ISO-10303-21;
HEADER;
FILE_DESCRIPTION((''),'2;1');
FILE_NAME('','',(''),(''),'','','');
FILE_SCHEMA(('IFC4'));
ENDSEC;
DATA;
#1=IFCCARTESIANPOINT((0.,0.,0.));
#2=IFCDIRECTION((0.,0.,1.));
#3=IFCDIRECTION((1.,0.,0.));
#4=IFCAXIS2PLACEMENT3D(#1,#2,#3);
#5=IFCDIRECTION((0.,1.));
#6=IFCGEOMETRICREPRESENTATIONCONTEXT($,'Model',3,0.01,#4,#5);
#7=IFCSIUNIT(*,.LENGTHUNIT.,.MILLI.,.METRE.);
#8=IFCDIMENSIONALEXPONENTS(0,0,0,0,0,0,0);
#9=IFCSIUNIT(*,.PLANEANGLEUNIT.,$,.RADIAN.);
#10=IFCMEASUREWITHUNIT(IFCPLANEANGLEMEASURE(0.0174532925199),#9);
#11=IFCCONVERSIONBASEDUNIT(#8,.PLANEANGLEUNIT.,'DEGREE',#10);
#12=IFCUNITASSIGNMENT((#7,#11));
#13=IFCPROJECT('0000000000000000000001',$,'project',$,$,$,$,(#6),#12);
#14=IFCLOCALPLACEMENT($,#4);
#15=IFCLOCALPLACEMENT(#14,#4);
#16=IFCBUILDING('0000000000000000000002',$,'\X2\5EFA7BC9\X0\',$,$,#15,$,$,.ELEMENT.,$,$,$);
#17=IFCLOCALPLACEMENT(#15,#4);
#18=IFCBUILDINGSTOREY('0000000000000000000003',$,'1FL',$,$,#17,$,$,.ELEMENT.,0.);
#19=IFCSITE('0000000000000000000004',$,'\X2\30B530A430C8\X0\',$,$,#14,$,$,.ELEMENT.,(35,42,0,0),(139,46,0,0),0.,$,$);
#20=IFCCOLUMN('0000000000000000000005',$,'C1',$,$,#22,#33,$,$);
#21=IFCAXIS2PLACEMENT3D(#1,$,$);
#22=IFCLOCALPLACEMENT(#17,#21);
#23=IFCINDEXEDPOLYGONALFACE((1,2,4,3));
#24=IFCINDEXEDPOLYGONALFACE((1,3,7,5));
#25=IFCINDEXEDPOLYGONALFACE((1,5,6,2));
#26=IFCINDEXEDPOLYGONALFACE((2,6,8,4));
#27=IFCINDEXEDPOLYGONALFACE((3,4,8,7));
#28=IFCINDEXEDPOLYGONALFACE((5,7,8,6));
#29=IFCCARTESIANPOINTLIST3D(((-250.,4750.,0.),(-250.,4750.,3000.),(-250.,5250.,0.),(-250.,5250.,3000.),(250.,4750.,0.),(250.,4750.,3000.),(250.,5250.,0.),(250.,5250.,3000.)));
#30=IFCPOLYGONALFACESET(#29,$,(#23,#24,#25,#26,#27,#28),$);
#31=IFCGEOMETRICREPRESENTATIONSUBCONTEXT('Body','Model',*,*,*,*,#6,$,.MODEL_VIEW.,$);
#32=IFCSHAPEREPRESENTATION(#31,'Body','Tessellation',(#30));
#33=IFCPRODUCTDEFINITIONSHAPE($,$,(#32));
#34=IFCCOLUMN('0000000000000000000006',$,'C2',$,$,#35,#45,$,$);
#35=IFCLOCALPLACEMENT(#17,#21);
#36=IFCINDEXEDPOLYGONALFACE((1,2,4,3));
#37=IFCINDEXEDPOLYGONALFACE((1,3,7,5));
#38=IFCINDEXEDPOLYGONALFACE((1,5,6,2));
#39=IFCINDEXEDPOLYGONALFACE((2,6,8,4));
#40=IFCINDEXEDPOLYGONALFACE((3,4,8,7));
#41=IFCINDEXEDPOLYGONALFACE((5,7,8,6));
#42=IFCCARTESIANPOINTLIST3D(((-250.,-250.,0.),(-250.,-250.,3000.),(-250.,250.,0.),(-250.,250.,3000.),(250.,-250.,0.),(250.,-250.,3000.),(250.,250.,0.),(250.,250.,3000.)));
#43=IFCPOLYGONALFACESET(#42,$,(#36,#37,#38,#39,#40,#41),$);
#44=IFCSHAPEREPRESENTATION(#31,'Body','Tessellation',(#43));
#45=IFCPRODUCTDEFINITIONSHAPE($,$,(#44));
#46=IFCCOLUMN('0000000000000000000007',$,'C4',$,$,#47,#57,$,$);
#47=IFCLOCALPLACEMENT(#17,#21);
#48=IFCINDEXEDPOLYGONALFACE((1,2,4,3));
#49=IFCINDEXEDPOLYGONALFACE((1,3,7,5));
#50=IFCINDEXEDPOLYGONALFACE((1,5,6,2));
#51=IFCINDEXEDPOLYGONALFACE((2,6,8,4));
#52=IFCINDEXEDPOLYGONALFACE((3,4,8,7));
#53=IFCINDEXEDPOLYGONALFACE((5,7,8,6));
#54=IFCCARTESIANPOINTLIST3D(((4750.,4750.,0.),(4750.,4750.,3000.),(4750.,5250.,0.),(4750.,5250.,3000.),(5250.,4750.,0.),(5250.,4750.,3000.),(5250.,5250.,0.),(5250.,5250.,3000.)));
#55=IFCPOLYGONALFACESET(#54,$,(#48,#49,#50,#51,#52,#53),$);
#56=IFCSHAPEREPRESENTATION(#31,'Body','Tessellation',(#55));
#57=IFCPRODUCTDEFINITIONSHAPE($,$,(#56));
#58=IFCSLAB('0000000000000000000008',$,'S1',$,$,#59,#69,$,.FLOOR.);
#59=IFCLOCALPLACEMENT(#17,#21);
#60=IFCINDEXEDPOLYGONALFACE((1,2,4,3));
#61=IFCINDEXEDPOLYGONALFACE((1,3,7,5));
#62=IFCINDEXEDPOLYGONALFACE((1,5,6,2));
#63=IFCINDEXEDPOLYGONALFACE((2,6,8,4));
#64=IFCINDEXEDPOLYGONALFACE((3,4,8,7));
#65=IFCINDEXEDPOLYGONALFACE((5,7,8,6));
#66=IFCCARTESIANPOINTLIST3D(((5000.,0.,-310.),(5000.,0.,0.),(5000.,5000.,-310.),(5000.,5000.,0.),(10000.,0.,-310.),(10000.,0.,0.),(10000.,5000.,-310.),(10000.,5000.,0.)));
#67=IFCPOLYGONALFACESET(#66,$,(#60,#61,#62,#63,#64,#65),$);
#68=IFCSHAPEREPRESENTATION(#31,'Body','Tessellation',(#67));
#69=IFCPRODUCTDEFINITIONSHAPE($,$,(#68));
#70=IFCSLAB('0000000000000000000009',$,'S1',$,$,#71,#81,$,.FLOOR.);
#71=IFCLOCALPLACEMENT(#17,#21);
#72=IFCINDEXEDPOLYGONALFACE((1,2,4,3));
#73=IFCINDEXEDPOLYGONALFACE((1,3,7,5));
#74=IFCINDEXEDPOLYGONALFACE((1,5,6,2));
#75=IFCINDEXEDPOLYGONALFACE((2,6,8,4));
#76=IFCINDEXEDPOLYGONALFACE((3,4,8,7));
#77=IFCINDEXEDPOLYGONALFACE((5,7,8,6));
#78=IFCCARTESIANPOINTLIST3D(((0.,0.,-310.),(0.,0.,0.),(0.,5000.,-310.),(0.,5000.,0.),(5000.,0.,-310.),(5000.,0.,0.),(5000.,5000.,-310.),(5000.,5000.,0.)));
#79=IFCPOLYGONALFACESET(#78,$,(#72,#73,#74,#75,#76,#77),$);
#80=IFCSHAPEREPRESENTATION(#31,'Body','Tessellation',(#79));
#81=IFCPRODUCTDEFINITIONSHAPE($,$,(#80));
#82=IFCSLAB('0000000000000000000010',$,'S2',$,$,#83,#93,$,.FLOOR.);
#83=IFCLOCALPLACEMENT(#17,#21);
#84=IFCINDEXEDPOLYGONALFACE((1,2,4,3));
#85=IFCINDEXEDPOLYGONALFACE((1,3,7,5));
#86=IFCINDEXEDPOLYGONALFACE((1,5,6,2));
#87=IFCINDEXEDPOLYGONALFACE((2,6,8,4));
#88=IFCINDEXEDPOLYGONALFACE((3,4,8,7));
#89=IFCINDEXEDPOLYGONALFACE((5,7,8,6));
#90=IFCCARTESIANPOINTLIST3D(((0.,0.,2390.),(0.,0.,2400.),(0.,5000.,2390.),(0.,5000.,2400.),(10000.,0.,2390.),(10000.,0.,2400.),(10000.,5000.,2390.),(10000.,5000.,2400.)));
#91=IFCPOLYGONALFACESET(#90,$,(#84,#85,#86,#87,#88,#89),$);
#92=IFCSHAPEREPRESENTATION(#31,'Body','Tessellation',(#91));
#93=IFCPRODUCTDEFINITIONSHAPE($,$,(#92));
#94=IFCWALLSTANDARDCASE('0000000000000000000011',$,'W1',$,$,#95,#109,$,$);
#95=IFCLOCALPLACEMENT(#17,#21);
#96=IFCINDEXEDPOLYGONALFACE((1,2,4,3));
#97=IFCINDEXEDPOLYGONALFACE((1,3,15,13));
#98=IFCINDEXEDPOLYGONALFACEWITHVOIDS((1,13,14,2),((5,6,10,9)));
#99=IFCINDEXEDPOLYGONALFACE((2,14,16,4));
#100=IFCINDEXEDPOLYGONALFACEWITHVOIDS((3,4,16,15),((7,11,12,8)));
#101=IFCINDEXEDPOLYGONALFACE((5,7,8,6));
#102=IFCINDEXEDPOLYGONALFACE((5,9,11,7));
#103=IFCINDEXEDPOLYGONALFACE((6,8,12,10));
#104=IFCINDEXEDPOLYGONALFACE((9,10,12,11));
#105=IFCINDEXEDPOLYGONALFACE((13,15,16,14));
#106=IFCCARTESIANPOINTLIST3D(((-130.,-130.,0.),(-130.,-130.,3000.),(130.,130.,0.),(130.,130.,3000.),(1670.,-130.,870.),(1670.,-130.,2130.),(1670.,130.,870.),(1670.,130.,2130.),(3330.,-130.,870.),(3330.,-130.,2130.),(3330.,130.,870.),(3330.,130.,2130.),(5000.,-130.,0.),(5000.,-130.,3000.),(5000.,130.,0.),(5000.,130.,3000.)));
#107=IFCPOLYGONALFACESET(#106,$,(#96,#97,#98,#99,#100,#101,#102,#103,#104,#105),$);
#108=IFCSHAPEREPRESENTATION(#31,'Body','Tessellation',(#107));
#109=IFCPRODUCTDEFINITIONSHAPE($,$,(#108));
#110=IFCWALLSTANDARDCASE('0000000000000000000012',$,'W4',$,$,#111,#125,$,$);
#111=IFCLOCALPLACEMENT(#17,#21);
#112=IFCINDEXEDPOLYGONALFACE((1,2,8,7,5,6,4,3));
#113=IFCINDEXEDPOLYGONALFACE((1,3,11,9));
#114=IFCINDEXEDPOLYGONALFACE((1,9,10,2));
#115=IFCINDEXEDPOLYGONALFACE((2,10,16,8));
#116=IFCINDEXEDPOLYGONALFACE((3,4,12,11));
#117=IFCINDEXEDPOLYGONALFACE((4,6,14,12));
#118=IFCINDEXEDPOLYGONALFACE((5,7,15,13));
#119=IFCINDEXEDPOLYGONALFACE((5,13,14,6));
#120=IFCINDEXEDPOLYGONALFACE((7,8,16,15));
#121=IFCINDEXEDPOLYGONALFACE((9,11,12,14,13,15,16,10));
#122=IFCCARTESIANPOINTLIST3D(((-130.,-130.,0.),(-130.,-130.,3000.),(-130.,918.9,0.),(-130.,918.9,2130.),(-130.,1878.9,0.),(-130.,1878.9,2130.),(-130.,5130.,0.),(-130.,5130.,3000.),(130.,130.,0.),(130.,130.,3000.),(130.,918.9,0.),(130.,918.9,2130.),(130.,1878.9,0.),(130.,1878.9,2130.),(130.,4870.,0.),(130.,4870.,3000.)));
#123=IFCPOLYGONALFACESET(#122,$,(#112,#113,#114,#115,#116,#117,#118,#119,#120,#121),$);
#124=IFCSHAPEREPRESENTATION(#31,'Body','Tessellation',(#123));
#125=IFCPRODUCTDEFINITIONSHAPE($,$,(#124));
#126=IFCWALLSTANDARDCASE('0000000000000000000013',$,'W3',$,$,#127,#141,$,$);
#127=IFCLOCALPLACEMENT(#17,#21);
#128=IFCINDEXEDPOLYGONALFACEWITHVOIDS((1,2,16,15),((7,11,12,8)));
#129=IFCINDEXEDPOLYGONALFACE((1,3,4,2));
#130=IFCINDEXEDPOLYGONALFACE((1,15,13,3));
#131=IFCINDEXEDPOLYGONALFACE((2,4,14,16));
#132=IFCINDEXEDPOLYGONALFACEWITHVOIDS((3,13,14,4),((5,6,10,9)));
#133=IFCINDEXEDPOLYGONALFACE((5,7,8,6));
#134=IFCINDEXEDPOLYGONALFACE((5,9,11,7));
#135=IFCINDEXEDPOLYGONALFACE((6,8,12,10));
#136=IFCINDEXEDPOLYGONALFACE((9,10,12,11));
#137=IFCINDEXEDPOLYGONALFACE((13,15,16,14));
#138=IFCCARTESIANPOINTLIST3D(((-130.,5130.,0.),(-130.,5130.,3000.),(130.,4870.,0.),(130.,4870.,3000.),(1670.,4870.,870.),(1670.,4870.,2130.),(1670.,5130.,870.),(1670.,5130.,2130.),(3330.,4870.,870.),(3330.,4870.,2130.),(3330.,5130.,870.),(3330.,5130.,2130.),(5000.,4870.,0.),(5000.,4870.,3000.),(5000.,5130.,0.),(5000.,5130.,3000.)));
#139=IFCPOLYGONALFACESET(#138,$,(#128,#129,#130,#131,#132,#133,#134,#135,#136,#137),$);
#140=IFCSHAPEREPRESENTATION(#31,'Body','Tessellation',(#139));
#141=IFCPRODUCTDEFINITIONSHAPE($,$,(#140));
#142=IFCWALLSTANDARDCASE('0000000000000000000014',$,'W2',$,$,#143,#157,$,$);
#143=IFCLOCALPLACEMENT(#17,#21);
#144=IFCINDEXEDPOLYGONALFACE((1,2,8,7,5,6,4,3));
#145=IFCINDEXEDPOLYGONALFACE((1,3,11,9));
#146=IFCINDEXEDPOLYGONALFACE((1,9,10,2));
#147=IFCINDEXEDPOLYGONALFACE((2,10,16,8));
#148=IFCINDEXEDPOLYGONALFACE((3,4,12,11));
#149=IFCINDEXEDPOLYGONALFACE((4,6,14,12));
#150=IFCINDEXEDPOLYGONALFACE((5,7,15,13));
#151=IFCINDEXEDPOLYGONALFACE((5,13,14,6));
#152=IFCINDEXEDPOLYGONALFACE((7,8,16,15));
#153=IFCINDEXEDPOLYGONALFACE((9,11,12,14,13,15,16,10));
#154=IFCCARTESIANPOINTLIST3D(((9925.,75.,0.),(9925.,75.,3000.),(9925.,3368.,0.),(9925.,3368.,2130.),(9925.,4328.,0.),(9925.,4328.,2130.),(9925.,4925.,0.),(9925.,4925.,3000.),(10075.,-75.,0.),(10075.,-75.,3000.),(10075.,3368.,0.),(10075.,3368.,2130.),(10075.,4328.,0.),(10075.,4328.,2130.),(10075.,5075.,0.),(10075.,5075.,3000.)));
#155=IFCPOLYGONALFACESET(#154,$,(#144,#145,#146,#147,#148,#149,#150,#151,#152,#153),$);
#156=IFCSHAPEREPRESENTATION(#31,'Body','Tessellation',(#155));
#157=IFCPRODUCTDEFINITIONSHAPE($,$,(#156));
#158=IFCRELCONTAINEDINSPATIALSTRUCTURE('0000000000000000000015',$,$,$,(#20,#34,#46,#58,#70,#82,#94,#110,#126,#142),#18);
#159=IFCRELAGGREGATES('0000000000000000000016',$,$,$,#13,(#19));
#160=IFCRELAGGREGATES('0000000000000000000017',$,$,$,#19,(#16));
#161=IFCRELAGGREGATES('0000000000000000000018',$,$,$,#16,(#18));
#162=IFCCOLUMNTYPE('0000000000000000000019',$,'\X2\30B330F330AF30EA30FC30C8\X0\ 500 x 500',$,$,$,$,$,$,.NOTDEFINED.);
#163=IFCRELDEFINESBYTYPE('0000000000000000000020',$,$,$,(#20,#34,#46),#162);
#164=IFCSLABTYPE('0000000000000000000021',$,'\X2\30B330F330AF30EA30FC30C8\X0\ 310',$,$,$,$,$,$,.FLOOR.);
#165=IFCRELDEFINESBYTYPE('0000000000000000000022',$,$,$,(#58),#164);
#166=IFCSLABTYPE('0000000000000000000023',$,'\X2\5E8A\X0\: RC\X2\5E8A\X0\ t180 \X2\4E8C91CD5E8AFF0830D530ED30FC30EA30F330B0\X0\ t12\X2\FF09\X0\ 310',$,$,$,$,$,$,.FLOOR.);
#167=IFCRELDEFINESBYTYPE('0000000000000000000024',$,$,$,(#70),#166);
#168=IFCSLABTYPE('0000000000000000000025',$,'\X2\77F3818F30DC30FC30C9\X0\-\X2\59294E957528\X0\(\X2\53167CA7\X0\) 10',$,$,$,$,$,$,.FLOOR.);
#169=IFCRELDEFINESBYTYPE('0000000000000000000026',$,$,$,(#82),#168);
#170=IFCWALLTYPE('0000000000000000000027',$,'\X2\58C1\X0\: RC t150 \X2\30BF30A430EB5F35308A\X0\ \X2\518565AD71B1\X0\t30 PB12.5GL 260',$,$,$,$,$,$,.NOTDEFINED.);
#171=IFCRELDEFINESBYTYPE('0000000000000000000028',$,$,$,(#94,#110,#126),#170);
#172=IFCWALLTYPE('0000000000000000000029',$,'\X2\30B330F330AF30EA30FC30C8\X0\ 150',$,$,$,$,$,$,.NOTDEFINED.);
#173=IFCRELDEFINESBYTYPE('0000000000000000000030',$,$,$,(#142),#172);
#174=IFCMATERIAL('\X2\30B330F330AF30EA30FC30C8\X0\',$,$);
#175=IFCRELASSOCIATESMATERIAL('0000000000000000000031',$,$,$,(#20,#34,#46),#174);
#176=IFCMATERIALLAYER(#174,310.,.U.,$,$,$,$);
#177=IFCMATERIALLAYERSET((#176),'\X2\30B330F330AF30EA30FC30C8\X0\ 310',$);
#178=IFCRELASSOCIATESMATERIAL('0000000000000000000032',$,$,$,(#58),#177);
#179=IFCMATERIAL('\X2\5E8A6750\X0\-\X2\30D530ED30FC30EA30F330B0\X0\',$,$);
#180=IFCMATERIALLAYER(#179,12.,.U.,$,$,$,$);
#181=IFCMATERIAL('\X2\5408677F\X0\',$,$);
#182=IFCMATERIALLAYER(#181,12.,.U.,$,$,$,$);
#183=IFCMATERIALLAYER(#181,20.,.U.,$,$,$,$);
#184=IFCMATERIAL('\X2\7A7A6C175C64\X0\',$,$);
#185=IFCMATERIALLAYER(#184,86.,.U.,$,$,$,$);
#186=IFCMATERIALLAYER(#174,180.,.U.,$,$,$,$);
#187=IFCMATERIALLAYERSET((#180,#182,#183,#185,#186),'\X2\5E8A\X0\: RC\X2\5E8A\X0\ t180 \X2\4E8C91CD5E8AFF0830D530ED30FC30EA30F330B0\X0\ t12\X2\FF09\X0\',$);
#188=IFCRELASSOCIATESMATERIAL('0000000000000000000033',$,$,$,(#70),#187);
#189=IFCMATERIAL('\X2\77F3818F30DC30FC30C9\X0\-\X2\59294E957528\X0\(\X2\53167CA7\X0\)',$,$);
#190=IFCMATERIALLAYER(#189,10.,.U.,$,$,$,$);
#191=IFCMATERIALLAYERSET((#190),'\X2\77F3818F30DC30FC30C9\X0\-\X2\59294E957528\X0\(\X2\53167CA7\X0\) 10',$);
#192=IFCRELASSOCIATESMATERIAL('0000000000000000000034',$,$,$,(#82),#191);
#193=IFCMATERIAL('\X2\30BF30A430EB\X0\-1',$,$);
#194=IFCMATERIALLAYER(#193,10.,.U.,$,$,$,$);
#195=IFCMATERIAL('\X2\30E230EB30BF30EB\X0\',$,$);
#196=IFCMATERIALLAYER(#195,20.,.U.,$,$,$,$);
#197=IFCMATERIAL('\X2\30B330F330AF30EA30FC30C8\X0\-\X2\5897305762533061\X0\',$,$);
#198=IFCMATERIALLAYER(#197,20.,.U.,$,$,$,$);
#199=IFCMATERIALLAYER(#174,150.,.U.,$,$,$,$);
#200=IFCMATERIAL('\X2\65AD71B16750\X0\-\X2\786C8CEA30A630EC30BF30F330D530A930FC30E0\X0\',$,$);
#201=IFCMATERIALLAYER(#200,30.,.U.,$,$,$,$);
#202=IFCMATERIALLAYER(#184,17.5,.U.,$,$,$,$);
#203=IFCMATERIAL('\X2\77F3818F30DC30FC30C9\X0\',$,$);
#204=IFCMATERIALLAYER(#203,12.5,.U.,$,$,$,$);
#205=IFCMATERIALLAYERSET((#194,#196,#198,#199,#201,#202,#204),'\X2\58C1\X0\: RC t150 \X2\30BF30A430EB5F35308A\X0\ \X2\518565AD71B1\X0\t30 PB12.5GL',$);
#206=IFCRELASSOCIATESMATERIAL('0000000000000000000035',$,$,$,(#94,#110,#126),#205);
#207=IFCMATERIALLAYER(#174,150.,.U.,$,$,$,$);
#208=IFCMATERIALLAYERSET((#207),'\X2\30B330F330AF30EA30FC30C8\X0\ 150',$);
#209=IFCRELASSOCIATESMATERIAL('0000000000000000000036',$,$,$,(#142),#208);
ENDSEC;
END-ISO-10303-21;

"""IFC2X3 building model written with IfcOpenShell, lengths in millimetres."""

from ifc_helpers import new_model, entity, si_unit, converted_unit, direction, frame, origin_with_axes, origin_2d_with_axis, place, context, subcontext, project, spatial, polyline, rectangle, outline, extrude, material, layer, layer_set, layer_usage, type_object, element, save


model = new_model("IFC2X3")

# Units and contexts
model_context = context("Model", 3, precision=0.01, world=origin_with_axes(), true_north=direction((0.0, 1.0)))
body_context = subcontext(model_context, "Body", "Model", "MODEL_VIEW")
ifc_project = project(units=[si_unit("LENGTHUNIT", "METRE", prefix="MILLI"), converted_unit("PLANEANGLEUNIT", "DEGREE", entity("IfcPlaneAngleMeasure", 0.0174532925199), si_unit("PLANEANGLEUNIT", "RADIAN"), dimensions=[0, 0, 0, 0, 0, 0, 0])], contexts=[model_context])

# Site, building, storey
site_placement = place(None, origin_with_axes())
site = spatial("IfcSite", under=ifc_project, at=site_placement, Name="サイト", CompositionType="ELEMENT", RefLatitude=(35, 42, 0, 0), RefLongitude=(139, 46, 0, 0), RefElevation=0.0)
building_placement = place(site_placement, origin_with_axes())
building = spatial("IfcBuilding", under=site, at=building_placement, Name="建築", CompositionType="ELEMENT")
storey_placement = place(building_placement, origin_with_axes())
storey = spatial("IfcBuildingStorey", under=building, at=storey_placement, Name="1FL", CompositionType="ELEMENT", Elevation=0.0)

# Columns
ifc_material_1 = material(Name="コンクリート")
column_type_1 = type_object("IfcColumnType", Name="コンクリート 500 x 500", PredefinedType="NOTDEFINED")
for number, where, z_axis, x_axis, name in (
    (1, (0.0, 5000.0, 0.0), (0.0, 0.0, 1.0), (1.0, 0.0, 0.0), "C1"),
    (2, (0.0, 0.0, 0.0), (0.0, 0.0, 1.0), (1.0, 0.0, 0.0), "C2"),
    (3, (5000.0, 5000.0, 0.0), (0.0, 0.0, 1.0), (1.0, 0.0, 0.0), "C4"),
):
    element("IfcColumn", number, at=place(storey_placement, frame(where, z_axis=z_axis, x_axis=x_axis)), inside=storey, type_object=column_type_1, material=ifc_material_1, Name=name, context=body_context, shape_type="SweptSolid", body=[
        extrude(rectangle(XDim=500.0, YDim=500.0, at=origin_2d_with_axis()), origin_with_axes(), (0.0, 0.0, 1.0), 3000.0),
    ])

# Slabs
ifc_layer_1 = layer(ifc_material_1, 310.0, ventilated="UNKNOWN")
ifc_layer_set_1 = layer_set([ifc_layer_1], Name="コンクリート 310")
ifc_layer_usage_1 = layer_usage(ifc_layer_set_1, "AXIS3", "NEGATIVE", 310.0)
slab_type_1 = type_object("IfcSlabType", Name="コンクリート 310", PredefinedType="FLOOR")
slab_1_placement = place(storey_placement, frame((5000.0, 0.0, 0.0), z_axis=(0.0, 0.0, 1.0), x_axis=(1.0, 0.0, 0.0)))
element("IfcSlab", 4, at=slab_1_placement, inside=storey, type_object=slab_type_1, material=ifc_layer_usage_1, Name="S1", PredefinedType="FLOOR", context=body_context, shape_type="SweptSolid", body=[
    extrude(outline(polyline([(0.0, 0.0), (5000.0, 0.0), (5000.0, 5000.0), (0.0, 5000.0), (0.0, 0.0)])), frame((0.0, 0.0, -310.0), z_axis=(0.0, 0.0, 1.0), x_axis=(1.0, 0.0, 0.0)), (0.0, 0.0, 1.0), 310.0),
])
ifc_material_2 = material(Name="床材-フローリング")
ifc_layer_2 = layer(ifc_material_2, 12.0, ventilated="UNKNOWN")
ifc_material_3 = material(Name="合板")
ifc_layer_3 = layer(ifc_material_3, 12.0, ventilated="UNKNOWN")
ifc_layer_4 = layer(ifc_material_3, 20.0, ventilated="UNKNOWN")
ifc_material_4 = material(Name="空気層")
ifc_layer_5 = layer(ifc_material_4, 86.0, ventilated="UNKNOWN")
ifc_layer_6 = layer(ifc_material_1, 180.0, ventilated="UNKNOWN")
ifc_layer_set_2 = layer_set([ifc_layer_2, ifc_layer_3, ifc_layer_4, ifc_layer_5, ifc_layer_6], Name="床: RC床 t180 二重床（フローリング t12）")
ifc_layer_usage_2 = layer_usage(ifc_layer_set_2, "AXIS3", "NEGATIVE", 310.0)
slab_type_2 = type_object("IfcSlabType", Name="床: RC床 t180 二重床（フローリング t12） 310", PredefinedType="FLOOR")
slab_2_placement = place(storey_placement, origin_with_axes())
element("IfcSlab", 5, at=slab_2_placement, inside=storey, type_object=slab_type_2, material=ifc_layer_usage_2, Name="S1", PredefinedType="FLOOR", context=body_context, shape_type="SweptSolid", body=[
    extrude(outline(polyline([(0.0, 0.0), (5000.0, 0.0), (5000.0, 5000.0), (0.0, 5000.0), (0.0, 0.0)])), frame((0.0, 0.0, -310.0), z_axis=(0.0, 0.0, 1.0), x_axis=(1.0, 0.0, 0.0)), (0.0, 0.0, 1.0), 310.0),
])
ifc_material_5 = material(Name="石膏ボード-天井用(化粧)")
ifc_layer_7 = layer(ifc_material_5, 10.0, ventilated="UNKNOWN")
ifc_layer_set_3 = layer_set([ifc_layer_7], Name="石膏ボード-天井用(化粧) 10")
ifc_layer_usage_3 = layer_usage(ifc_layer_set_3, "AXIS3", "NEGATIVE", 10.0)
slab_type_3 = type_object("IfcSlabType", Name="石膏ボード-天井用(化粧) 10", PredefinedType="FLOOR")
slab_3_placement = place(storey_placement, frame((0.0, 0.0, 2400.0), z_axis=(0.0, 0.0, 1.0), x_axis=(1.0, 0.0, 0.0)))
element("IfcSlab", 6, at=slab_3_placement, inside=storey, type_object=slab_type_3, material=ifc_layer_usage_3, Name="S2", PredefinedType="FLOOR", context=body_context, shape_type="SweptSolid", body=[
    extrude(outline(polyline([(0.0, 0.0), (10000.0, 0.0), (10000.0, 5000.0), (0.0, 5000.0), (0.0, 0.0)])), frame((0.0, 0.0, -10.0), z_axis=(0.0, 0.0, 1.0), x_axis=(1.0, 0.0, 0.0)), (0.0, 0.0, 1.0), 10.0),
])

# Walls, openings
ifc_material_6 = material(Name="タイル-1")
ifc_layer_8 = layer(ifc_material_6, 10.0, ventilated="UNKNOWN")
ifc_material_7 = material(Name="モルタル")
ifc_layer_9 = layer(ifc_material_7, 20.0, ventilated="UNKNOWN")
ifc_material_8 = material(Name="コンクリート-増し打ち")
ifc_layer_10 = layer(ifc_material_8, 20.0, ventilated="UNKNOWN")
ifc_layer_11 = layer(ifc_material_1, 150.0, ventilated="UNKNOWN")
ifc_material_9 = material(Name="断熱材-硬質ウレタンフォーム")
ifc_layer_12 = layer(ifc_material_9, 30.0, ventilated="UNKNOWN")
ifc_layer_13 = layer(ifc_material_4, 17.5, ventilated="UNKNOWN")
ifc_material_10 = material(Name="石膏ボード")
ifc_layer_14 = layer(ifc_material_10, 12.5, ventilated="UNKNOWN")
ifc_layer_set_4 = layer_set([ifc_layer_8, ifc_layer_9, ifc_layer_10, ifc_layer_11, ifc_layer_12, ifc_layer_13, ifc_layer_14], Name="壁: RC t150 タイル張り 内断熱t30 PB12.5GL")
ifc_layer_usage_4 = layer_usage(ifc_layer_set_4, "AXIS2", "POSITIVE", -130.0)
wall_type_1 = type_object("IfcWallType", Name="壁: RC t150 タイル張り 内断熱t30 PB12.5GL 260", PredefinedType="NOTDEFINED")
wall_1_placement = place(storey_placement, origin_with_axes())
wall_1 = element("IfcWallStandardCase", 7, at=wall_1_placement, inside=storey, type_object=wall_type_1, material=ifc_layer_usage_4, Name="W1", context=body_context, shape_type="SweptSolid", body=[
    extrude(outline(polyline([(-130.0, -130.0), (5000.0, -130.0), (5000.0, 130.0), (130.0, 130.0), (-130.0, -130.0)])), origin_with_axes(), (0.0, 0.0, 1.0), 3000.0),
])
opening_1_placement = place(wall_1_placement, frame((2500.0, 0.0, 900.0), z_axis=(0.0, 0.0, 1.0), x_axis=(1.0, 0.0, 0.0)))
element("IfcOpeningElement", 8, at=opening_1_placement, cuts=wall_1, context=body_context, shape_type="SweptSolid", body=[
    extrude(rectangle(XDim=1660.0, YDim=1260.0, at=origin_2d_with_axis()), frame((0.0, -305.0, 600.0), z_axis=(0.0, 1.0, 0.0), x_axis=(-1.0, 0.0, 0.0)), (0.0, 0.0, 1.0), 610.0),
])
ifc_layer_usage_5 = layer_usage(ifc_layer_set_4, "AXIS2", "POSITIVE", -130.0)
wall_2_placement = place(storey_placement, frame((0.0, 5000.0, 0.0), z_axis=(0.0, 0.0, 1.0), x_axis=(0.0, -1.0, 0.0)))
wall_2 = element("IfcWallStandardCase", 9, at=wall_2_placement, inside=storey, type_object=wall_type_1, material=ifc_layer_usage_5, Name="W4", context=body_context, shape_type="SweptSolid", body=[
    extrude(outline(polyline([(-130.0, -130.0), (5130.0, -130.0), (4870.0, 130.0), (130.0, 130.0), (-130.0, -130.0)])), origin_with_axes(), (0.0, 0.0, 1.0), 3000.0),
])
opening_2_placement = place(wall_2_placement, frame((3601.1, 0.0, 0.0), z_axis=(0.0, 0.0, 1.0), x_axis=(1.0, 0.0, 0.0)))
element("IfcOpeningElement", 10, at=opening_2_placement, cuts=wall_2, context=body_context, shape_type="SweptSolid", body=[
    extrude(outline(polyline([(-480.0, -2130.0), (480.0, -2130.0), (480.0, 0.0), (-480.0, 0.0), (-480.0, -2130.0)])), frame((0.0, 270.0, 0.0), z_axis=(0.0, -1.0, 0.0), x_axis=(-1.0, 0.0, 0.0)), (0.0, 0.0, 1.0), 540.0),
])
ifc_layer_usage_6 = layer_usage(ifc_layer_set_4, "AXIS2", "POSITIVE", -130.0)
wall_3_placement = place(storey_placement, frame((5000.0, 5000.0, 0.0), z_axis=(0.0, 0.0, 1.0), x_axis=(-1.0, 0.0, 0.0)))
wall_3 = element("IfcWallStandardCase", 11, at=wall_3_placement, inside=storey, type_object=wall_type_1, material=ifc_layer_usage_6, Name="W3", context=body_context, shape_type="SweptSolid", body=[
    extrude(outline(polyline([(0.0, -130.0), (5130.0, -130.0), (4870.0, 130.0), (0.0, 130.0), (0.0, -130.0)])), origin_with_axes(), (0.0, 0.0, 1.0), 3000.0),
])
opening_3_placement = place(wall_3_placement, frame((2500.0, 0.0, 900.0), z_axis=(0.0, 0.0, 1.0), x_axis=(1.0, 0.0, 0.0)))
element("IfcOpeningElement", 12, at=opening_3_placement, cuts=wall_3, context=body_context, shape_type="SweptSolid", body=[
    extrude(rectangle(XDim=1660.0, YDim=1260.0, at=origin_2d_with_axis()), frame((0.0, -305.0, 600.0), z_axis=(0.0, 1.0, 0.0), x_axis=(-1.0, 0.0, 0.0)), (0.0, 0.0, 1.0), 610.0),
])
ifc_layer_15 = layer(ifc_material_1, 150.0, ventilated="UNKNOWN")
ifc_layer_set_5 = layer_set([ifc_layer_15], Name="コンクリート 150")
ifc_layer_usage_7 = layer_usage(ifc_layer_set_5, "AXIS2", "POSITIVE", -75.0)
wall_type_2 = type_object("IfcWallType", Name="コンクリート 150", PredefinedType="NOTDEFINED")
wall_4_placement = place(storey_placement, frame((10000.0, 0.0, 0.0), z_axis=(0.0, 0.0, 1.0), x_axis=(0.0, 1.0, 0.0)))
wall_4 = element("IfcWallStandardCase", 13, at=wall_4_placement, inside=storey, type_object=wall_type_2, material=ifc_layer_usage_7, Name="W2", context=body_context, shape_type="SweptSolid", body=[
    extrude(outline(polyline([(-75.0, -75.0), (5075.0, -75.0), (4925.0, 75.0), (75.0, 75.0), (-75.0, -75.0)])), origin_with_axes(), (0.0, 0.0, 1.0), 3000.0),
])
opening_4_placement = place(wall_4_placement, frame((3848.0, 0.0, 0.0), z_axis=(0.0, 0.0, 1.0), x_axis=(1.0, 0.0, 0.0)))
element("IfcOpeningElement", 14, at=opening_4_placement, cuts=wall_4, context=body_context, shape_type="SweptSolid", body=[
    extrude(outline(polyline([(-480.0, -2130.0), (480.0, -2130.0), (480.0, 0.0), (-480.0, 0.0), (-480.0, -2130.0)])), frame((0.0, 160.0, 0.0), z_axis=(0.0, 1.0, 0.0), x_axis=(1.0, 0.0, 0.0)), (0.0, 0.0, -1.0), 320.0),
])

save(model, "model.ifc")
